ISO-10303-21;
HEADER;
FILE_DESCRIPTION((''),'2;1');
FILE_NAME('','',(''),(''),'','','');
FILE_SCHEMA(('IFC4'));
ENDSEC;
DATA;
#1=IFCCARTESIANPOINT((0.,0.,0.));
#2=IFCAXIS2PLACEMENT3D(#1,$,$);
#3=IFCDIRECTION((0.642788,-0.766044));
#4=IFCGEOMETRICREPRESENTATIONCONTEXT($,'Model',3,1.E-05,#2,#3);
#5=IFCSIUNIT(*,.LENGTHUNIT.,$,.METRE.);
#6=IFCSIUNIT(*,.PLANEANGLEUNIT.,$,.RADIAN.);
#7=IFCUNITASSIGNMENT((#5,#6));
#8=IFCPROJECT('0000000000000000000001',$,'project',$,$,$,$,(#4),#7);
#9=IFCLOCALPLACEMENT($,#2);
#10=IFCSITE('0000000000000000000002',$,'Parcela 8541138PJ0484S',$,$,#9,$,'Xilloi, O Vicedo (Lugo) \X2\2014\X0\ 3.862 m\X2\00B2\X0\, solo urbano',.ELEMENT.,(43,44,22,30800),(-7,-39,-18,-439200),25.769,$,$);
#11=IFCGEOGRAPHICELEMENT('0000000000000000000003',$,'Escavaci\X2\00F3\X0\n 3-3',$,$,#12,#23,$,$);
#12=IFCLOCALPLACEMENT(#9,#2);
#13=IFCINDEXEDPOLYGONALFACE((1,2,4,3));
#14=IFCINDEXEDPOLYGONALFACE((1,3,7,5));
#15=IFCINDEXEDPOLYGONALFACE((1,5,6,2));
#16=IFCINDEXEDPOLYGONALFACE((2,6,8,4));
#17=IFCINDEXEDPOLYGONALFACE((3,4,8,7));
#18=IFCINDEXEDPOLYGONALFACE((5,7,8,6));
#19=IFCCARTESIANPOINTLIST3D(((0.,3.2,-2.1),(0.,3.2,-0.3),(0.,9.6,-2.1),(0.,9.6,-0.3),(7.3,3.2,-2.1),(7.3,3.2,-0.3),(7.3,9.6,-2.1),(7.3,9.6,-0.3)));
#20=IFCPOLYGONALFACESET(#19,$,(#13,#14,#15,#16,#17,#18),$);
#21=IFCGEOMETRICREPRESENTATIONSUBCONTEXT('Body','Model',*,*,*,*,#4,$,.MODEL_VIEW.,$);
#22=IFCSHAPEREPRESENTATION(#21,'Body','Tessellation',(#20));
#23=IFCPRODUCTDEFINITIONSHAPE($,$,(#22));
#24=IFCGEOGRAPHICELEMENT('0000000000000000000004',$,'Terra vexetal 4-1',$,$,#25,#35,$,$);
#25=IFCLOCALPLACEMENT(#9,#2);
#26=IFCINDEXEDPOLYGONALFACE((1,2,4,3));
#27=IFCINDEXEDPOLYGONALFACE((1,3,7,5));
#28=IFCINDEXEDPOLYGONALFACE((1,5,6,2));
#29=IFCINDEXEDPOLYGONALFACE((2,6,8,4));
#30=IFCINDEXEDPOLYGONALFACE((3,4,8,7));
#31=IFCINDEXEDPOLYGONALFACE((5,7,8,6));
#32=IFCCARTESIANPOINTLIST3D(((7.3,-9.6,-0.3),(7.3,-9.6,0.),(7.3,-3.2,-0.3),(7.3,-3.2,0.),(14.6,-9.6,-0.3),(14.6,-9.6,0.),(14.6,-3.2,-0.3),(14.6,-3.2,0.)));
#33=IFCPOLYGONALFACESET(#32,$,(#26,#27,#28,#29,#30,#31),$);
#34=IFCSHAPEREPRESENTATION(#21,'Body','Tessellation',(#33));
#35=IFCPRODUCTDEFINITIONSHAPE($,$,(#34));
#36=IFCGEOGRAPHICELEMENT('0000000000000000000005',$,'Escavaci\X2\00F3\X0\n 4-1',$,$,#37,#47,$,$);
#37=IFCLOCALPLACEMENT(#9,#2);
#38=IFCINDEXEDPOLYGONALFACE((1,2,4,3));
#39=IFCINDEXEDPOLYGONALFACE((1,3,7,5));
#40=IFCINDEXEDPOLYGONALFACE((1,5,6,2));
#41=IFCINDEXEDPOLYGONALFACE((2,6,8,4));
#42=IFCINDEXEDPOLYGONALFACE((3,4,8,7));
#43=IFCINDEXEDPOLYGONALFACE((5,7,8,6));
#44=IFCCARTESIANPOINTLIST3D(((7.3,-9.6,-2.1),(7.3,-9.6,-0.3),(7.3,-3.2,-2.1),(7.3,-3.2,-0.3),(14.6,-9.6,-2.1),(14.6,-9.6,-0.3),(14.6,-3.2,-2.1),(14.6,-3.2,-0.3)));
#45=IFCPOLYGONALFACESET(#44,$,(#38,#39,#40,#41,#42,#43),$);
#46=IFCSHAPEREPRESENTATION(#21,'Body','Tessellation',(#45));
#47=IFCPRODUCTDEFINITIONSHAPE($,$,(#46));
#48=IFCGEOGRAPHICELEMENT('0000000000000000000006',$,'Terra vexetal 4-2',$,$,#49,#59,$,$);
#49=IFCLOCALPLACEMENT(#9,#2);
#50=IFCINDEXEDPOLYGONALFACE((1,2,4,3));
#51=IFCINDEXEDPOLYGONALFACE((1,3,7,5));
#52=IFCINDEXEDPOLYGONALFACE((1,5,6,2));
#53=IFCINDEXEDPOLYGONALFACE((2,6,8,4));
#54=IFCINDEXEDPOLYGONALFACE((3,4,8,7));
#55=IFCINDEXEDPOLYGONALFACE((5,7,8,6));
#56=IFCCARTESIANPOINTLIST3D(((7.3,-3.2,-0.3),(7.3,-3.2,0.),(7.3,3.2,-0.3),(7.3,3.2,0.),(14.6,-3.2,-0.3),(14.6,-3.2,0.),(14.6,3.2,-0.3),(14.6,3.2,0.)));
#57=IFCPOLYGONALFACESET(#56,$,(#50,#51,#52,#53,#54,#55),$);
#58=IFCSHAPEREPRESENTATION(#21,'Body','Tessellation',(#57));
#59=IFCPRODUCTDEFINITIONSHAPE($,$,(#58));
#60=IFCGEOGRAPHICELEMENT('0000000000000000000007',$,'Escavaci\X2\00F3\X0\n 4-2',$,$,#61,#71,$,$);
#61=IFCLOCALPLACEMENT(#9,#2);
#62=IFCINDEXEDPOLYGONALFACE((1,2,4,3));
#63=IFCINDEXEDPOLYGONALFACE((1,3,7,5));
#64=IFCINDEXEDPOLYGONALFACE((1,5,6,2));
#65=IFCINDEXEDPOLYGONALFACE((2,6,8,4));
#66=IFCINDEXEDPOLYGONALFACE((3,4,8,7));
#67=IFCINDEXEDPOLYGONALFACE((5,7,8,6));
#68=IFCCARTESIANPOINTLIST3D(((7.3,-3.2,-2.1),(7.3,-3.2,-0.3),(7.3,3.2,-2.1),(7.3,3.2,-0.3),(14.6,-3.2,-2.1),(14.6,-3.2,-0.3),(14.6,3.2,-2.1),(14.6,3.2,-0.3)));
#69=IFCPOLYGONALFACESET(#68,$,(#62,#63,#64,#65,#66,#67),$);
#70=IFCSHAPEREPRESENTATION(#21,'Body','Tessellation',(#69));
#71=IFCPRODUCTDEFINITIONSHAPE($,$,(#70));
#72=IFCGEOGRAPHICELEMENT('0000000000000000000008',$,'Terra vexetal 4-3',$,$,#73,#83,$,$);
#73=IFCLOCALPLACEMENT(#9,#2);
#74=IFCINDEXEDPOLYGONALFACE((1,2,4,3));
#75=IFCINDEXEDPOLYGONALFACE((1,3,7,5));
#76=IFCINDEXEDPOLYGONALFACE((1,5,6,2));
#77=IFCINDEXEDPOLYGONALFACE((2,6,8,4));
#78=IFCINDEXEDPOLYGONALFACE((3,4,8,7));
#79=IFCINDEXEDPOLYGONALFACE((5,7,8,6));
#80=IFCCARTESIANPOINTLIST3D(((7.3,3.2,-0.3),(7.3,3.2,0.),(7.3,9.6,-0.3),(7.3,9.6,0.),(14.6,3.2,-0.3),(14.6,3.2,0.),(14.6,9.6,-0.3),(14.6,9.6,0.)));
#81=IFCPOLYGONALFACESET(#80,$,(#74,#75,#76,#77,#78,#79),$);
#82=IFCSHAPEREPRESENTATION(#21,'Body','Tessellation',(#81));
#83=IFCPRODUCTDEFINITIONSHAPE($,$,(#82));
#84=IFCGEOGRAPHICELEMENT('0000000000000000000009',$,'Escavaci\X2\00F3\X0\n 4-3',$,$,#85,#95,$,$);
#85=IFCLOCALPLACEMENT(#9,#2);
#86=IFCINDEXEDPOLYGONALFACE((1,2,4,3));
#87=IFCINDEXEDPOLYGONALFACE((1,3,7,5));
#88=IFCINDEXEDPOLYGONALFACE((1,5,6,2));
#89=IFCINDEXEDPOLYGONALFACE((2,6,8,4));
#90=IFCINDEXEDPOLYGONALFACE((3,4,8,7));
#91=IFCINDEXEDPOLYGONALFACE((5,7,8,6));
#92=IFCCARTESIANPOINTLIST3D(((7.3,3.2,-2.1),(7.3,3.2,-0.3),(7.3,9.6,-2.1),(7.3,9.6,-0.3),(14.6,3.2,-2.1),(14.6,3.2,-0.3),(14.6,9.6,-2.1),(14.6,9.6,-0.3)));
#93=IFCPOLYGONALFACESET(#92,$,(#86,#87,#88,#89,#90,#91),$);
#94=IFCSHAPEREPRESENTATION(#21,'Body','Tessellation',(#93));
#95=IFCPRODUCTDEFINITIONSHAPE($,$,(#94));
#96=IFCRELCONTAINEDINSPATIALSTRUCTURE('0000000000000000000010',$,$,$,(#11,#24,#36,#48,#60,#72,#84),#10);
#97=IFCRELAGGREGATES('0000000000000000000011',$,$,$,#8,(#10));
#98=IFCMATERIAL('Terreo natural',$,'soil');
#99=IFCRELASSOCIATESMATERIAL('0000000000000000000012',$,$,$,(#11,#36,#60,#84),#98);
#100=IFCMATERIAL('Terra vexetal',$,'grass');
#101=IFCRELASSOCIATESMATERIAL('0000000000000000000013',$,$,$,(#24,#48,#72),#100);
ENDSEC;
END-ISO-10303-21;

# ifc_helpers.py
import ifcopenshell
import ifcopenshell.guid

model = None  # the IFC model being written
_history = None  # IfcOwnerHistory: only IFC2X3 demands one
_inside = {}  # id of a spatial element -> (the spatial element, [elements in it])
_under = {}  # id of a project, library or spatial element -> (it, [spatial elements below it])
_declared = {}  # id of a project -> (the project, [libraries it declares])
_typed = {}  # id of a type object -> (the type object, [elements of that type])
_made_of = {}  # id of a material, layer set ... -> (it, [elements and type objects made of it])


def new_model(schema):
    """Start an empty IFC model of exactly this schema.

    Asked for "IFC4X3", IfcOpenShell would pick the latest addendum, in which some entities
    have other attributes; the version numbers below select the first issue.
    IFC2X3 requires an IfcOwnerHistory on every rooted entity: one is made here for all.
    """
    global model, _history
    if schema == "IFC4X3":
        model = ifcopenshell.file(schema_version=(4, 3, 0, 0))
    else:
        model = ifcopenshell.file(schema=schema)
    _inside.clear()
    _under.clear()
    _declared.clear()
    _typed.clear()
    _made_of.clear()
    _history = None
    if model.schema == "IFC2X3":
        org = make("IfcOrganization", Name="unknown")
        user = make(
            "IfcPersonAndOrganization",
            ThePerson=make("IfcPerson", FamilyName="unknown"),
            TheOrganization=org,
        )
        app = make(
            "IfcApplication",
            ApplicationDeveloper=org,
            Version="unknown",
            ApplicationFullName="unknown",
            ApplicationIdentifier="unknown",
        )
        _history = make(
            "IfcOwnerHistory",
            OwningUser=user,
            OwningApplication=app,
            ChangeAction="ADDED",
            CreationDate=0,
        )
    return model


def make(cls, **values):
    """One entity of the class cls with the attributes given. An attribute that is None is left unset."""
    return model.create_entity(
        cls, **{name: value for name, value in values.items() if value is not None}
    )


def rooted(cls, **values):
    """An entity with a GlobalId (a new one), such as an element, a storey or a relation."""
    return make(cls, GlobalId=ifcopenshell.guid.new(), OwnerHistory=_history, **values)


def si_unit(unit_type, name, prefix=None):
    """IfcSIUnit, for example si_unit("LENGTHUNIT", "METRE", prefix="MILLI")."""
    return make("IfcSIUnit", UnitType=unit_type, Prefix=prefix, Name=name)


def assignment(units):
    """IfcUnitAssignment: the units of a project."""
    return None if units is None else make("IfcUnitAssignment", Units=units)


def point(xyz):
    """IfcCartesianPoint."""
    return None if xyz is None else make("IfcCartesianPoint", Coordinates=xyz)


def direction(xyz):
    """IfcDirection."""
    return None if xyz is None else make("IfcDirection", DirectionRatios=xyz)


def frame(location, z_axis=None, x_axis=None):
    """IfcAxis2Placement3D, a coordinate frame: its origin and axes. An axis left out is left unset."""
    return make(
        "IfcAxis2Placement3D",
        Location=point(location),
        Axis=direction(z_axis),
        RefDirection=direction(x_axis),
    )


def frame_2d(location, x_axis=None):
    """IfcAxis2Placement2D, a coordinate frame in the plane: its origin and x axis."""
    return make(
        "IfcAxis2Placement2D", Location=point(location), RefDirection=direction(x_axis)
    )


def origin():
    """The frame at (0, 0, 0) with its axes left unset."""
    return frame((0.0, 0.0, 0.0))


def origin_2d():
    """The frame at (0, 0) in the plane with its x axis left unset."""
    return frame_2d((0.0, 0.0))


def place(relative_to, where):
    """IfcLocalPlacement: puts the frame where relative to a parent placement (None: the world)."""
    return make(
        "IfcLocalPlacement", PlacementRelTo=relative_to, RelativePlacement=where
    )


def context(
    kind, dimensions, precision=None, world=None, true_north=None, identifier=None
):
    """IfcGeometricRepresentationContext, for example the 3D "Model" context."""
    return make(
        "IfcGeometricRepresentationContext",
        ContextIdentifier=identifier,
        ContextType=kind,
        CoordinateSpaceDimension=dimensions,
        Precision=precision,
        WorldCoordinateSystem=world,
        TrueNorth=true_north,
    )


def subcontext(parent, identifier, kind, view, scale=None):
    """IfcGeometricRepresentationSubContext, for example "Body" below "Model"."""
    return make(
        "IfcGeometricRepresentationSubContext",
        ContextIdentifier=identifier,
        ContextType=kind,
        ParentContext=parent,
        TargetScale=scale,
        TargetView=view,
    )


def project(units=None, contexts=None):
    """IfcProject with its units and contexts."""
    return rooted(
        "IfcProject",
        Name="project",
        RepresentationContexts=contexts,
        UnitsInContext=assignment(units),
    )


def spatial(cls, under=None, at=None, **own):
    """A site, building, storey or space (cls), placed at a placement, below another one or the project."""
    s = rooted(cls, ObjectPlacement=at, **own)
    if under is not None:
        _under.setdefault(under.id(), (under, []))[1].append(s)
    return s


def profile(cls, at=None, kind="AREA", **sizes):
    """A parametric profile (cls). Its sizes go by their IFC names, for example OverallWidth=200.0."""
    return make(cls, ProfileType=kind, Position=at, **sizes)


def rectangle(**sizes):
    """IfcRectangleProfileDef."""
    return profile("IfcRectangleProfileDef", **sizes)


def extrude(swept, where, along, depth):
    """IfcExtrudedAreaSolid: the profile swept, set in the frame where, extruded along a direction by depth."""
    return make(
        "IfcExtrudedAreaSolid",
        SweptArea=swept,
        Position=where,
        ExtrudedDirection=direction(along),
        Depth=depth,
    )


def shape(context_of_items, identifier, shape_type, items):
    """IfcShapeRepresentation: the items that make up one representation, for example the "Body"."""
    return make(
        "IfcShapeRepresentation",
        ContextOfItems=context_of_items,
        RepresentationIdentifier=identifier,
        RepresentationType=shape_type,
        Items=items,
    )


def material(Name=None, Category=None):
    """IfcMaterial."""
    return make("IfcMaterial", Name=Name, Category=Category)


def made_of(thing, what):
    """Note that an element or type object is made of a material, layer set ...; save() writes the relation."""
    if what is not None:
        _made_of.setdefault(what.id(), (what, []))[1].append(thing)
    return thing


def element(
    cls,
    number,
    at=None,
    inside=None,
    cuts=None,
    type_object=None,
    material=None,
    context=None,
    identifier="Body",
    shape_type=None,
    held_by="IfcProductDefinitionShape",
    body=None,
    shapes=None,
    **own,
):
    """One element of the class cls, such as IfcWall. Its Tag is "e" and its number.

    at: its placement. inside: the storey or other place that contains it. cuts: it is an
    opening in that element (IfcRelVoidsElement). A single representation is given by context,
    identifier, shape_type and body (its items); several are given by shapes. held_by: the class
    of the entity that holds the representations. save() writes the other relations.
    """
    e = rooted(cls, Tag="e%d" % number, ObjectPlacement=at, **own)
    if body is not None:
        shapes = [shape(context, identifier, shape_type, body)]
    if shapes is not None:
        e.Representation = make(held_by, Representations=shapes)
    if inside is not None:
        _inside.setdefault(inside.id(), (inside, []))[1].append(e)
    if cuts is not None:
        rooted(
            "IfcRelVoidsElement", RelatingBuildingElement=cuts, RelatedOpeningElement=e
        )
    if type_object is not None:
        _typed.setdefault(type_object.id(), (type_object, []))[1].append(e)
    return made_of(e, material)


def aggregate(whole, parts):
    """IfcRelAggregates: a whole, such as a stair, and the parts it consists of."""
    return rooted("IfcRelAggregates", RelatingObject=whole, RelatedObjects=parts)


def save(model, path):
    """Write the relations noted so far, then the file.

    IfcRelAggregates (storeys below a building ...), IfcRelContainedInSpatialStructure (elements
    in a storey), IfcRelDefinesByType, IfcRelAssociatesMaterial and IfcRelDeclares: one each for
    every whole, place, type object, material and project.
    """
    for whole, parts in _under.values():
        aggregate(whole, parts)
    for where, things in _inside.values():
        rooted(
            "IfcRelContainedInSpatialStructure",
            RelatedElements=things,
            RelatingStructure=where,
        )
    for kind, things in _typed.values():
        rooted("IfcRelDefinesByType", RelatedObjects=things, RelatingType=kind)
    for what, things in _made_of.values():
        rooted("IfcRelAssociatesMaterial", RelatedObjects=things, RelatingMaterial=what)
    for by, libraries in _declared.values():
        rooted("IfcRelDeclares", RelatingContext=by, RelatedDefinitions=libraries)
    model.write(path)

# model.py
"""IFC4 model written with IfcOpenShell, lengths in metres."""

from ifc_helpers import new_model, si_unit, direction, frame, origin, origin_2d, place, context, subcontext, project, spatial, rectangle, extrude, material, element, save


model = new_model("IFC4")

# Units and contexts
model_context = context("Model", 3, precision=1e-05, world=origin(), true_north=direction((0.642788, -0.766044)))
body_context = subcontext(model_context, "Body", "Model", "MODEL_VIEW")
ifc_project = project(units=[si_unit("LENGTHUNIT", "METRE"), si_unit("PLANEANGLEUNIT", "RADIAN")], contexts=[model_context])

# Site
site_placement = place(None, origin())
site = spatial("IfcSite", under=ifc_project, at=site_placement, Name="Parcela 8541138PJ0484S", LongName="Xilloi, O Vicedo (Lugo) — 3.862 m², solo urbano", CompositionType="ELEMENT", RefLatitude=(43, 44, 22, 30800), RefLongitude=(-7, -39, -18, -439200), RefElevation=25.769)

# Geographic elements
ifc_material_1 = material(Name="Terra vexetal", Category="grass")
ifc_material_2 = material(Name="Terreo natural", Category="soil")
geographic_element_1_placement = place(site_placement, frame((3.65, 6.4, -1.2)))
element("IfcGeographicElement", 1, at=geographic_element_1_placement, inside=site, material=ifc_material_2, Name="Escavación 3-3", context=body_context, shape_type="SweptSolid", body=[
    extrude(rectangle(XDim=7.3, YDim=6.4, at=origin_2d()), frame((0.0, 0.0, -0.9)), (0.0, 0.0, 1.0), 1.8),
])
geographic_element_2_placement = place(site_placement, frame((10.95, -6.4, -0.15)))
element("IfcGeographicElement", 2, at=geographic_element_2_placement, inside=site, material=ifc_material_1, Name="Terra vexetal 4-1", context=body_context, shape_type="SweptSolid", body=[
    extrude(rectangle(XDim=7.3, YDim=6.4, at=origin_2d()), frame((0.0, 0.0, -0.15)), (0.0, 0.0, 1.0), 0.3),
])
geographic_element_3_placement = place(site_placement, frame((10.95, -6.4, -1.2)))
element("IfcGeographicElement", 3, at=geographic_element_3_placement, inside=site, material=ifc_material_2, Name="Escavación 4-1", context=body_context, shape_type="SweptSolid", body=[
    extrude(rectangle(XDim=7.3, YDim=6.4, at=origin_2d()), frame((0.0, 0.0, -0.9)), (0.0, 0.0, 1.0), 1.8),
])
geographic_element_4_placement = place(site_placement, frame((10.95, 0.0, -0.15)))
element("IfcGeographicElement", 4, at=geographic_element_4_placement, inside=site, material=ifc_material_1, Name="Terra vexetal 4-2", context=body_context, shape_type="SweptSolid", body=[
    extrude(rectangle(XDim=7.3, YDim=6.4, at=origin_2d()), frame((0.0, 0.0, -0.15)), (0.0, 0.0, 1.0), 0.3),
])
geographic_element_5_placement = place(site_placement, frame((10.95, 0.0, -1.2)))
element("IfcGeographicElement", 5, at=geographic_element_5_placement, inside=site, material=ifc_material_2, Name="Escavación 4-2", context=body_context, shape_type="SweptSolid", body=[
    extrude(rectangle(XDim=7.3, YDim=6.4, at=origin_2d()), frame((0.0, 0.0, -0.9)), (0.0, 0.0, 1.0), 1.8),
])
geographic_element_6_placement = place(site_placement, frame((10.95, 6.4, -0.15)))
element("IfcGeographicElement", 6, at=geographic_element_6_placement, inside=site, material=ifc_material_1, Name="Terra vexetal 4-3", context=body_context, shape_type="SweptSolid", body=[
    extrude(rectangle(XDim=7.3, YDim=6.4, at=origin_2d()), frame((0.0, 0.0, -0.15)), (0.0, 0.0, 1.0), 0.3),
])
geographic_element_7_placement = place(site_placement, frame((10.95, 6.4, -1.2)))
element("IfcGeographicElement", 7, at=geographic_element_7_placement, inside=site, material=ifc_material_2, Name="Escavación 4-3", context=body_context, shape_type="SweptSolid", body=[
    extrude(rectangle(XDim=7.3, YDim=6.4, at=origin_2d()), frame((0.0, 0.0, -0.9)), (0.0, 0.0, 1.0), 1.8),
])

save(model, "model.ifc")
